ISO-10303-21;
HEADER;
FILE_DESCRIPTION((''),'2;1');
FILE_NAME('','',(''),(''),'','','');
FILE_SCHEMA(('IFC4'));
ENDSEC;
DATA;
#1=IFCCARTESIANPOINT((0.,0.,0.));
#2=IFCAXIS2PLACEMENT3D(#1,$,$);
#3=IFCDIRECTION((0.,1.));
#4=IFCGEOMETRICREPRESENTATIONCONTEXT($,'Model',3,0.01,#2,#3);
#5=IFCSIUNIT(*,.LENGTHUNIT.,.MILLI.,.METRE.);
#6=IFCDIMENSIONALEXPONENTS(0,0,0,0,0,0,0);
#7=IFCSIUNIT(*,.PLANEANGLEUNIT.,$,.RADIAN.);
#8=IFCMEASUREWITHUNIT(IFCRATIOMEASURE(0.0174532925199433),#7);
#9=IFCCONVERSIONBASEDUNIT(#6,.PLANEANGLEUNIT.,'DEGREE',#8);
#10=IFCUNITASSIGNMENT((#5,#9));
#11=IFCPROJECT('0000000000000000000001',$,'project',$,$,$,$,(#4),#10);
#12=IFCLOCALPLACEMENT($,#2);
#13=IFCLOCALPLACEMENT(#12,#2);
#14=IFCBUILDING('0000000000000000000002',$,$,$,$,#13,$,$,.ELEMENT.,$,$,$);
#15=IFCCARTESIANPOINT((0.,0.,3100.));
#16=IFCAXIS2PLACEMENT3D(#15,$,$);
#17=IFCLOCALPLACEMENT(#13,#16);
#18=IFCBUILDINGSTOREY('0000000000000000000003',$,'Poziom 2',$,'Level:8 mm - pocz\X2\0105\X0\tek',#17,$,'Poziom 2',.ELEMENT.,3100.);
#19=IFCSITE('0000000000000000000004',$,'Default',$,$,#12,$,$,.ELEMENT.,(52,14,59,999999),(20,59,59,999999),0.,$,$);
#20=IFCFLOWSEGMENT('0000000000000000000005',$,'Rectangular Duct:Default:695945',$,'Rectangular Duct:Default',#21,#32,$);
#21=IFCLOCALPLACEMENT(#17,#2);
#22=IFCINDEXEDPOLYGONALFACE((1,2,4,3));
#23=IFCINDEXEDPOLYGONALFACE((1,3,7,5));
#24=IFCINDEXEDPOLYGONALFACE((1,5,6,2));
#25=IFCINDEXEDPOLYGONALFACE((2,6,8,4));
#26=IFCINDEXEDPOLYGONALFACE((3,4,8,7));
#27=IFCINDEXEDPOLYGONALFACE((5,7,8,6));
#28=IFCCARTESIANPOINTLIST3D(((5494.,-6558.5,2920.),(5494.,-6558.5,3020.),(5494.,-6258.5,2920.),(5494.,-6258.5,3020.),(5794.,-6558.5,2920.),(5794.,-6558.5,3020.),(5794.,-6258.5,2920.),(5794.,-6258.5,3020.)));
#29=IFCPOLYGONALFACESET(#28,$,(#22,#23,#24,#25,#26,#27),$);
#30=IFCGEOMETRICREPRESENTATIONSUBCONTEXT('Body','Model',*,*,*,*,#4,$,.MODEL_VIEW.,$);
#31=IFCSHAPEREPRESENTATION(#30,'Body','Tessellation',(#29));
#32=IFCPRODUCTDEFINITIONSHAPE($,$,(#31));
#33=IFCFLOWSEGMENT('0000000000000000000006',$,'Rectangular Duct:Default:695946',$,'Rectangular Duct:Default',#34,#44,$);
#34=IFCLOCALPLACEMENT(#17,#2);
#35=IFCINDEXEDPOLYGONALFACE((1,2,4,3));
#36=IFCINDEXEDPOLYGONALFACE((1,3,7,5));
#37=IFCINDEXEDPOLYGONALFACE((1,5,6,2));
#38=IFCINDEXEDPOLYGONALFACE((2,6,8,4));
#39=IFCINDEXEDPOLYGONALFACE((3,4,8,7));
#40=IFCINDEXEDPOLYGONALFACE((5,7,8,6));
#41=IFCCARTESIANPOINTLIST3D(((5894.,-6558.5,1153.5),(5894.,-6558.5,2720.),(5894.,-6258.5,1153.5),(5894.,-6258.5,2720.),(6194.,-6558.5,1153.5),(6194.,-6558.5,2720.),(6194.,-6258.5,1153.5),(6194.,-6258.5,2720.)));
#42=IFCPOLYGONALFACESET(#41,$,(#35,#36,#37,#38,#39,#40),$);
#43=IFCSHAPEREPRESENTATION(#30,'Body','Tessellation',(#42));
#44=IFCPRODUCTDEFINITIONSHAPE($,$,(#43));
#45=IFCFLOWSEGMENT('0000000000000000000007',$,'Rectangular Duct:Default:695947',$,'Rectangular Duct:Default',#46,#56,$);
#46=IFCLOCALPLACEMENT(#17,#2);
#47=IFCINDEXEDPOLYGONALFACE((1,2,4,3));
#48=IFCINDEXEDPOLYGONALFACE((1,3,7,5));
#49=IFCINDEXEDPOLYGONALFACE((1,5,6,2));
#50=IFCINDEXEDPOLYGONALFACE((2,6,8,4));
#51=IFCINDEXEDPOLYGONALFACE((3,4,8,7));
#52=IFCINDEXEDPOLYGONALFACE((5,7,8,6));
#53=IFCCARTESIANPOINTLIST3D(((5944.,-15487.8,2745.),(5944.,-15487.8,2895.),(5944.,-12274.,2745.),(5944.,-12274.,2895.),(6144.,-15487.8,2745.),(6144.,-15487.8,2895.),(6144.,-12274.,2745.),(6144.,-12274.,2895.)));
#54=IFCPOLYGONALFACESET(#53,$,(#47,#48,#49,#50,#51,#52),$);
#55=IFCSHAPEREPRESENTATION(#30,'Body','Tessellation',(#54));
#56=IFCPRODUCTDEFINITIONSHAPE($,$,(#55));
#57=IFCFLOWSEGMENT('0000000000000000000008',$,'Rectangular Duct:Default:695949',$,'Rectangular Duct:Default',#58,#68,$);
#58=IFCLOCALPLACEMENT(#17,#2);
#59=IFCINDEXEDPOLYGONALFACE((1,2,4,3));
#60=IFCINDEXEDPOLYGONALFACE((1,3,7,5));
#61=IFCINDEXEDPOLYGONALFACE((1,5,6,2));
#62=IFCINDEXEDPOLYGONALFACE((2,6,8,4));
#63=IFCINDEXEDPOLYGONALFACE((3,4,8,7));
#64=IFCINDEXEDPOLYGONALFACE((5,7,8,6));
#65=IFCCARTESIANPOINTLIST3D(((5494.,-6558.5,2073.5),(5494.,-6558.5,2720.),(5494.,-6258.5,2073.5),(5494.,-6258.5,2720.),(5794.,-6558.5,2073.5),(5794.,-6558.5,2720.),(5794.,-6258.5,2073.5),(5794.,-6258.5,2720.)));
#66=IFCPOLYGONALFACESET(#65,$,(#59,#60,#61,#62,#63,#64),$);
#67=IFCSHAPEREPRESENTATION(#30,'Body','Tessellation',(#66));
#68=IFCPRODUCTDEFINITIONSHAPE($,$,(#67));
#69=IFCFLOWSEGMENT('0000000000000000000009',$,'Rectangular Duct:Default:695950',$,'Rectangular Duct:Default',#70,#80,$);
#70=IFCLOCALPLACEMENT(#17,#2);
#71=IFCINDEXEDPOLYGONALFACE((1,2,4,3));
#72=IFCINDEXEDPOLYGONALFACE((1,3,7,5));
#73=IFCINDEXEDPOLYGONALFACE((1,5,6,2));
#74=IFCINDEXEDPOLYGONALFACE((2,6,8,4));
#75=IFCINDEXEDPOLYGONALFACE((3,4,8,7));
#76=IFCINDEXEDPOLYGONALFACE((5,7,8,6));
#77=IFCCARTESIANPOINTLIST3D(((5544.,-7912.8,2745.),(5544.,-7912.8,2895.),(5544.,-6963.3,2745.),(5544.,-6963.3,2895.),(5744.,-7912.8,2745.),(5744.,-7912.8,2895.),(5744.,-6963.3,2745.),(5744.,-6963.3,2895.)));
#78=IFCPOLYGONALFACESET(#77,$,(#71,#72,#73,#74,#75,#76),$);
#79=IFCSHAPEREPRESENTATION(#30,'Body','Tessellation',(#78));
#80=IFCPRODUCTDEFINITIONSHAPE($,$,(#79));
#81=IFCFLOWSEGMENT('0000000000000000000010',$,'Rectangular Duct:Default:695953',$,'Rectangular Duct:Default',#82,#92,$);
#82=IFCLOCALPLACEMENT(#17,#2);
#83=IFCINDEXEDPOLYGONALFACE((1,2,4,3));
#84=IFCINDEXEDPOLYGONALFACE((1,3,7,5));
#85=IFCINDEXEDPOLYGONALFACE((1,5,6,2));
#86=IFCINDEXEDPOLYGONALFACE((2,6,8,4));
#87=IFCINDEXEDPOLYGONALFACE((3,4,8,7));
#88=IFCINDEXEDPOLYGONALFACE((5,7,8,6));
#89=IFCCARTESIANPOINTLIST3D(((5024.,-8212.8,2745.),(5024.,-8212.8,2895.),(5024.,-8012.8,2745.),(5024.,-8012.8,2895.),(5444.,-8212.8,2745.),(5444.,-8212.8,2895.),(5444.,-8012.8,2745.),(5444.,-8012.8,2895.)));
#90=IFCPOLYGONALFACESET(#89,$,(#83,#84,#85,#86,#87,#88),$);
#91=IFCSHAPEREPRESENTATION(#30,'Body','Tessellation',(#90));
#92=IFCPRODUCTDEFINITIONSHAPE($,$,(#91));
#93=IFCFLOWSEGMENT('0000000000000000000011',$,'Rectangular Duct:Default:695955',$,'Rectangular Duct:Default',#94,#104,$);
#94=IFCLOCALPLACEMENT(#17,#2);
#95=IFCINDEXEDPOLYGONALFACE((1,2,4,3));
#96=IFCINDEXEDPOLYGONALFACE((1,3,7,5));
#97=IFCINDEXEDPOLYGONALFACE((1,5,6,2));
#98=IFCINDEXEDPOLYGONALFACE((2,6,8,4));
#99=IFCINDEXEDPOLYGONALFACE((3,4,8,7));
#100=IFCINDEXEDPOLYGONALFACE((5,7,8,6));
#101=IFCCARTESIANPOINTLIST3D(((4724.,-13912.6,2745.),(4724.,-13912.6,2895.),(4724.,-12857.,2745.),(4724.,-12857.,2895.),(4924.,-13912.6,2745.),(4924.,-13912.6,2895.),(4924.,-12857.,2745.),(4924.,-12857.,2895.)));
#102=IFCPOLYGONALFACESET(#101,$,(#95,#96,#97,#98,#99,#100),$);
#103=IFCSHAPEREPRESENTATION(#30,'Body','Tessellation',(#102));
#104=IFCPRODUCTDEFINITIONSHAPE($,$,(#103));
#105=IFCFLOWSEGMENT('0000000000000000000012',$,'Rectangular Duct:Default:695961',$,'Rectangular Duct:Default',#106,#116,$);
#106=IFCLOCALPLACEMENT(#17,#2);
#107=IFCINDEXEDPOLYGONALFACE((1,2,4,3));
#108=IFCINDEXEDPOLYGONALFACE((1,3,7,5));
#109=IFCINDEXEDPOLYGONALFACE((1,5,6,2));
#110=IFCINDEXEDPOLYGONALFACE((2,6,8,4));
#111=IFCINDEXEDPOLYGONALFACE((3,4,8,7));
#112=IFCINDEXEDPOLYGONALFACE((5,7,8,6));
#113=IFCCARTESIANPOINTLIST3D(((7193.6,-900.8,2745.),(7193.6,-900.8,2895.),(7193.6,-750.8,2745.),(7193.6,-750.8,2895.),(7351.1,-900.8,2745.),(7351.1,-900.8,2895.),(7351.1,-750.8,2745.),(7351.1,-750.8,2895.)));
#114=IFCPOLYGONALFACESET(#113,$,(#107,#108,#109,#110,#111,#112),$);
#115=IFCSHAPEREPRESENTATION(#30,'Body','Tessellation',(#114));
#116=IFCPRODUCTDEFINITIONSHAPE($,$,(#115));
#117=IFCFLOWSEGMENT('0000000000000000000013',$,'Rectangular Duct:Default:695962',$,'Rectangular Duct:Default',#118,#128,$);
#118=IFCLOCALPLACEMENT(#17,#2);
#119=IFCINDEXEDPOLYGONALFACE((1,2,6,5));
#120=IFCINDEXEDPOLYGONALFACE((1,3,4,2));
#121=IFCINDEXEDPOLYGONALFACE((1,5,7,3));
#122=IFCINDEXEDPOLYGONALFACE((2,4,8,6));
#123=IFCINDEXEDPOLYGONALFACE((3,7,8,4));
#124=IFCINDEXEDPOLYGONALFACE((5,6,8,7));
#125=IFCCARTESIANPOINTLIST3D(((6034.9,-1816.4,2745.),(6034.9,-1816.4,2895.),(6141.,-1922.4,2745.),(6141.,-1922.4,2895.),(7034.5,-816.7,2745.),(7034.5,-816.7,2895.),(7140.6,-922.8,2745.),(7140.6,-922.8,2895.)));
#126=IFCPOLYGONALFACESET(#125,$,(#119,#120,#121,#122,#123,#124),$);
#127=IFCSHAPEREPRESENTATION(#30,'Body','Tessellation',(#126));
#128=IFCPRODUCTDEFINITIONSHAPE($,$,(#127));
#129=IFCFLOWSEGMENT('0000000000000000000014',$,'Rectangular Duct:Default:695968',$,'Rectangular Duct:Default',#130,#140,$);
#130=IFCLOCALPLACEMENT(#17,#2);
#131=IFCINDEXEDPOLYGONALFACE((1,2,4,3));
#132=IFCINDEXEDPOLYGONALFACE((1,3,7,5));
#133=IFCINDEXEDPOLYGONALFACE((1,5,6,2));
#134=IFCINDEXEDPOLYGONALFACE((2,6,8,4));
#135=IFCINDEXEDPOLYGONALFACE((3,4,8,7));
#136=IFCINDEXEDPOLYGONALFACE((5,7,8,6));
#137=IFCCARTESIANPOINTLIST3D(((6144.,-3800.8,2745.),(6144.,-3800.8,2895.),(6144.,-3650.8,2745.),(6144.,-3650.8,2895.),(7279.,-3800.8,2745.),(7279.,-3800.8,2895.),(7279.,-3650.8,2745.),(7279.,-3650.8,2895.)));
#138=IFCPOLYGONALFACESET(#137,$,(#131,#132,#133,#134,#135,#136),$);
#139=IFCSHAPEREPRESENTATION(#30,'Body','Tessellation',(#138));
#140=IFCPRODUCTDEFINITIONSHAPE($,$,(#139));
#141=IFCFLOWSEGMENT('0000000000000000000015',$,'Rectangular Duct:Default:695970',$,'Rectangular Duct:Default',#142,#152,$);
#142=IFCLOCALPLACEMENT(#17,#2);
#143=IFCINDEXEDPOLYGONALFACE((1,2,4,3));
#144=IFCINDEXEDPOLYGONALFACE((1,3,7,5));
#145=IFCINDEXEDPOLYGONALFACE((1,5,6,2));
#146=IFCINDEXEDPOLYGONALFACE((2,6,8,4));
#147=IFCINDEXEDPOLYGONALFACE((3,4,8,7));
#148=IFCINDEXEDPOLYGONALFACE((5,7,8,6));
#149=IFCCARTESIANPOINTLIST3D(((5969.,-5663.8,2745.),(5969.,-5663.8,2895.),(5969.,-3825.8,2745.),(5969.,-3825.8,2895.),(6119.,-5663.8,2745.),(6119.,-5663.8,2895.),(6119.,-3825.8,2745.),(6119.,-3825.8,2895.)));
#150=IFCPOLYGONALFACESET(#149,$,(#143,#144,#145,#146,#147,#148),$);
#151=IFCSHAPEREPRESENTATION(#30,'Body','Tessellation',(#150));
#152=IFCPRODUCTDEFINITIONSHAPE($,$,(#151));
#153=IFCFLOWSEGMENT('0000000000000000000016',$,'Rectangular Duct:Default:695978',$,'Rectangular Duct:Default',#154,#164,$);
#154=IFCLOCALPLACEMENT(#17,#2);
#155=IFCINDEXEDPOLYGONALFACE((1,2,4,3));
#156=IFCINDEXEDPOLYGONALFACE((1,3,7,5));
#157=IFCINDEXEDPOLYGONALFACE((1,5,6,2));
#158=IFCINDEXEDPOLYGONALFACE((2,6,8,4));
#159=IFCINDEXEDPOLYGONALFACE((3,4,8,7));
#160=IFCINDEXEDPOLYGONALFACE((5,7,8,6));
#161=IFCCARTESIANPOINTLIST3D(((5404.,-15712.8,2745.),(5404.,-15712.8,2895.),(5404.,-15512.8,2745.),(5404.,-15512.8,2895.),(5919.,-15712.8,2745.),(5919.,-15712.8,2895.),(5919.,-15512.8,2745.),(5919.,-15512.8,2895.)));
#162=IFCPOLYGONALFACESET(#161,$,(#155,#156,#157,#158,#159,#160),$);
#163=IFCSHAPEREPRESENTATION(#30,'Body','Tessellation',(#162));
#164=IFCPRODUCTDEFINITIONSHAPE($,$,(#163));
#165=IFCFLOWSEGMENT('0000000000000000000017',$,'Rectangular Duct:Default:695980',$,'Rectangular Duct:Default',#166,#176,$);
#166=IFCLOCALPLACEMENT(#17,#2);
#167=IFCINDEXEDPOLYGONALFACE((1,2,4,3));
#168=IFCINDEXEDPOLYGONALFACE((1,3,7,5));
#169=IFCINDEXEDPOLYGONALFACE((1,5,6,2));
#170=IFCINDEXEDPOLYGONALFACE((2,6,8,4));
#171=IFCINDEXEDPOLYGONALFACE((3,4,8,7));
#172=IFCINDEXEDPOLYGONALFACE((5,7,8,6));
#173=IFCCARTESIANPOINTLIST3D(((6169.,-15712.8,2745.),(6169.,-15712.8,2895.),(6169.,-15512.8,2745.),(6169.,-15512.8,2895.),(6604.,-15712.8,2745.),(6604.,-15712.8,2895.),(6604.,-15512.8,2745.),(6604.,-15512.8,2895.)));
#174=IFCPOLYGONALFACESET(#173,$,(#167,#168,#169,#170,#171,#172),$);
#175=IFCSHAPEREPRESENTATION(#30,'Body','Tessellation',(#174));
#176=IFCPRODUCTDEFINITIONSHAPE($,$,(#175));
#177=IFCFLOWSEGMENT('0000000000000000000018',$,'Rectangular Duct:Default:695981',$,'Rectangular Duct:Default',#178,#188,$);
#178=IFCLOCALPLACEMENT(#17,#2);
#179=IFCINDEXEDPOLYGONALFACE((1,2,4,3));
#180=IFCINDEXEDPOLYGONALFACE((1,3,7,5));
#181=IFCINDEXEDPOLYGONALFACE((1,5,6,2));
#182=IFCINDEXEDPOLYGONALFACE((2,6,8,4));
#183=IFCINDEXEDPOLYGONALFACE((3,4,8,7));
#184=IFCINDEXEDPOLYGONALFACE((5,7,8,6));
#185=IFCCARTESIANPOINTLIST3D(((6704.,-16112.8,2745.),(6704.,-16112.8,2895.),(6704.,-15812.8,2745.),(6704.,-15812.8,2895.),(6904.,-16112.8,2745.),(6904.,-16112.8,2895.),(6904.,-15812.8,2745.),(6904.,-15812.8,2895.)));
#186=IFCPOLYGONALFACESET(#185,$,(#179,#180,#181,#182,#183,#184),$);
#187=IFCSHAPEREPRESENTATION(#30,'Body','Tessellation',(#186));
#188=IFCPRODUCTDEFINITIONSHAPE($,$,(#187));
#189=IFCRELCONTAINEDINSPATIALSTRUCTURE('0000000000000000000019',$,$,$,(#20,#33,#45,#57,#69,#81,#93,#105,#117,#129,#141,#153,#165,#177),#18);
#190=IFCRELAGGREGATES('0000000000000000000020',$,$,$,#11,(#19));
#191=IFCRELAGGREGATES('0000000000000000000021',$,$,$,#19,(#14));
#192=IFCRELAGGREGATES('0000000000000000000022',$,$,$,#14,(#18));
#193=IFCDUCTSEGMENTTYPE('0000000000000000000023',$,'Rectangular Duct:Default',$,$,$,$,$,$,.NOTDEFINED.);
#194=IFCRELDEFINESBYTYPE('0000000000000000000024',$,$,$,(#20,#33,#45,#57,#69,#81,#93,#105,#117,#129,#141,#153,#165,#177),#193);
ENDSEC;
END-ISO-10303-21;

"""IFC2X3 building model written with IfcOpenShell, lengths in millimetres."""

from ifc_helpers import new_model, entity, si_unit, converted_unit, direction, frame, frame_2d, origin, origin_2d_with_axis, place, context, subcontext, project, spatial, rectangle, extrude, type_object, element, save


model = new_model("IFC2X3")

# Units and contexts
model_context = context("Model", 3, precision=0.01, world=origin(), true_north=direction((0.0, 1.0)))
body_context = subcontext(model_context, "Body", "Model", "MODEL_VIEW")
ifc_project = project(units=[si_unit("LENGTHUNIT", "METRE", prefix="MILLI"), converted_unit("PLANEANGLEUNIT", "DEGREE", entity("IfcRatioMeasure", 0.0174532925199433), si_unit("PLANEANGLEUNIT", "RADIAN"), dimensions=[0, 0, 0, 0, 0, 0, 0])], contexts=[model_context])

# Site, building, storey
site_placement = place(None, origin())
site = spatial("IfcSite", under=ifc_project, at=site_placement, Name="Default", CompositionType="ELEMENT", RefLatitude=(52, 14, 59, 999999), RefLongitude=(20, 59, 59, 999999), RefElevation=0.0)
building_placement = place(site_placement, origin())
building = spatial("IfcBuilding", under=site, at=building_placement, CompositionType="ELEMENT")
storey_placement = place(building_placement, frame((0.0, 0.0, 3100.0)))
storey = spatial("IfcBuildingStorey", under=building, at=storey_placement, Name="Poziom 2", ObjectType="Level:8 mm - początek", LongName="Poziom 2", CompositionType="ELEMENT", Elevation=3100.0)

# Flow segments
duct_segment_type = type_object("IfcDuctSegmentType", Name="Rectangular Duct:Default", PredefinedType="NOTDEFINED")
flow_segment_1_placement = place(storey_placement, origin())
element("IfcFlowSegment", 1, at=flow_segment_1_placement, inside=storey, type_object=duct_segment_type, Name="Rectangular Duct:Default:695945", ObjectType="Rectangular Duct:Default", context=body_context, shape_type="SweptSolid", body=[
    extrude(rectangle(XDim=300.0, YDim=300.0, at=frame_2d((0.0, 0.0), x_axis=(1.0, 0.0))), frame((5644.0, -6408.5, 2920.0), z_axis=(0.0, 0.0, 1.0), x_axis=(0.0, 1.0, 0.0)), (0.0, 0.0, 1.0), 100.0),
])
flow_segment_2_placement = place(storey_placement, origin())
element("IfcFlowSegment", 2, at=flow_segment_2_placement, inside=storey, type_object=duct_segment_type, Name="Rectangular Duct:Default:695946", ObjectType="Rectangular Duct:Default", context=body_context, shape_type="SweptSolid", body=[
    extrude(rectangle(XDim=300.0, YDim=300.0, at=frame_2d((0.0, 0.0), x_axis=(1.0, 0.0))), frame((6044.0, -6408.5, 1153.5), z_axis=(0.0, 0.0, 1.0), x_axis=(0.0, -1.0, 0.0)), (0.0, 0.0, 1.0), 1566.5),
])
flow_segment_3_placement = place(storey_placement, origin())
element("IfcFlowSegment", 3, at=flow_segment_3_placement, inside=storey, type_object=duct_segment_type, Name="Rectangular Duct:Default:695947", ObjectType="Rectangular Duct:Default", context=body_context, shape_type="SweptSolid", body=[
    extrude(rectangle(XDim=3213.8, YDim=200.0, at=origin_2d_with_axis()), frame((6044.0, -13880.9, 2745.0), z_axis=(0.0, 0.0, 1.0), x_axis=(0.0, -1.0, 0.0)), (0.0, 0.0, 1.0), 150.0),
])
flow_segment_4_placement = place(storey_placement, origin())
element("IfcFlowSegment", 4, at=flow_segment_4_placement, inside=storey, type_object=duct_segment_type, Name="Rectangular Duct:Default:695949", ObjectType="Rectangular Duct:Default", context=body_context, shape_type="SweptSolid", body=[
    extrude(rectangle(XDim=300.0, YDim=300.0, at=frame_2d((0.0, 0.0), x_axis=(1.0, 0.0))), frame((5644.0, -6408.5, 2073.5), z_axis=(0.0, 0.0, 1.0), x_axis=(0.0, 1.0, 0.0)), (0.0, 0.0, 1.0), 646.5),
])
flow_segment_5_placement = place(storey_placement, origin())
element("IfcFlowSegment", 5, at=flow_segment_5_placement, inside=storey, type_object=duct_segment_type, Name="Rectangular Duct:Default:695950", ObjectType="Rectangular Duct:Default", context=body_context, shape_type="SweptSolid", body=[
    extrude(rectangle(XDim=949.5, YDim=200.0, at=frame_2d((0.0, 0.0), x_axis=(1.0, 0.0))), frame((5644.0, -7438.0, 2745.0), z_axis=(0.0, 0.0, 1.0), x_axis=(0.0, -1.0, 0.0)), (0.0, 0.0, 1.0), 150.0),
])
flow_segment_6_placement = place(storey_placement, origin())
element("IfcFlowSegment", 6, at=flow_segment_6_placement, inside=storey, type_object=duct_segment_type, Name="Rectangular Duct:Default:695953", ObjectType="Rectangular Duct:Default", context=body_context, shape_type="SweptSolid", body=[
    extrude(rectangle(XDim=420.0, YDim=200.0, at=origin_2d_with_axis()), frame((5234.0, -8112.8, 2745.0), z_axis=(0.0, 0.0, 1.0), x_axis=(-1.0, 0.0, 0.0)), (0.0, 0.0, 1.0), 150.0),
])
flow_segment_7_placement = place(storey_placement, origin())
element("IfcFlowSegment", 7, at=flow_segment_7_placement, inside=storey, type_object=duct_segment_type, Name="Rectangular Duct:Default:695955", ObjectType="Rectangular Duct:Default", context=body_context, shape_type="SweptSolid", body=[
    extrude(rectangle(XDim=1055.6, YDim=200.0, at=frame_2d((0.0, 0.0), x_axis=(1.0, 0.0))), frame((4824.0, -13384.8, 2745.0), z_axis=(0.0, 0.0, 1.0), x_axis=(0.0, -1.0, 0.0)), (0.0, 0.0, 1.0), 150.0),
])
flow_segment_8_placement = place(storey_placement, origin())
element("IfcFlowSegment", 8, at=flow_segment_8_placement, inside=storey, type_object=duct_segment_type, Name="Rectangular Duct:Default:695961", ObjectType="Rectangular Duct:Default", context=body_context, shape_type="SweptSolid", body=[
    extrude(rectangle(XDim=157.5, YDim=150.0, at=frame_2d((0.0, 0.0), x_axis=(1.0, 0.0))), frame((7272.4, -825.8, 2745.0)), (0.0, 0.0, 1.0), 150.0),
])
flow_segment_9_placement = place(storey_placement, origin())
element("IfcFlowSegment", 9, at=flow_segment_9_placement, inside=storey, type_object=duct_segment_type, Name="Rectangular Duct:Default:695962", ObjectType="Rectangular Duct:Default", context=body_context, shape_type="SweptSolid", body=[
    extrude(rectangle(XDim=1413.7, YDim=150.0, at=frame_2d((0.0, 0.0), x_axis=(1.0, 0.0))), frame((6587.7, -1369.6, 2745.0), z_axis=(0.0, 0.0, 1.0), x_axis=(0.707107, 0.707107, 0.0)), (0.0, 0.0, 1.0), 150.0),
])
flow_segment_10_placement = place(storey_placement, origin())
element("IfcFlowSegment", 10, at=flow_segment_10_placement, inside=storey, type_object=duct_segment_type, Name="Rectangular Duct:Default:695968", ObjectType="Rectangular Duct:Default", context=body_context, shape_type="SweptSolid", body=[
    extrude(rectangle(XDim=1135.0, YDim=150.0, at=frame_2d((0.0, 0.0), x_axis=(1.0, 0.0))), frame((6711.5, -3725.8, 2745.0)), (0.0, 0.0, 1.0), 150.0),
])
flow_segment_11_placement = place(storey_placement, origin())
element("IfcFlowSegment", 11, at=flow_segment_11_placement, inside=storey, type_object=duct_segment_type, Name="Rectangular Duct:Default:695970", ObjectType="Rectangular Duct:Default", context=body_context, shape_type="SweptSolid", body=[
    extrude(rectangle(XDim=1838.0, YDim=150.0, at=frame_2d((0.0, 0.0), x_axis=(1.0, 0.0))), frame((6044.0, -4744.8, 2745.0), z_axis=(0.0, 0.0, 1.0), x_axis=(0.0, 1.0, 0.0)), (0.0, 0.0, 1.0), 150.0),
])
flow_segment_12_placement = place(storey_placement, origin())
element("IfcFlowSegment", 12, at=flow_segment_12_placement, inside=storey, type_object=duct_segment_type, Name="Rectangular Duct:Default:695978", ObjectType="Rectangular Duct:Default", context=body_context, shape_type="SweptSolid", body=[
    extrude(rectangle(XDim=515.0, YDim=200.0, at=frame_2d((0.0, 0.0), x_axis=(1.0, 0.0))), frame((5661.5, -15612.8, 2745.0), z_axis=(0.0, 0.0, 1.0), x_axis=(-1.0, 0.0, 0.0)), (0.0, 0.0, 1.0), 150.0),
])
flow_segment_13_placement = place(storey_placement, origin())
element("IfcFlowSegment", 13, at=flow_segment_13_placement, inside=storey, type_object=duct_segment_type, Name="Rectangular Duct:Default:695980", ObjectType="Rectangular Duct:Default", context=body_context, shape_type="SweptSolid", body=[
    extrude(rectangle(XDim=435.0, YDim=200.0, at=frame_2d((0.0, 0.0), x_axis=(1.0, 0.0))), frame((6386.5, -15612.8, 2745.0), z_axis=(0.0, 0.0, 1.0), x_axis=(-1.0, 0.0, 0.0)), (0.0, 0.0, 1.0), 150.0),
])
flow_segment_14_placement = place(storey_placement, origin())
element("IfcFlowSegment", 14, at=flow_segment_14_placement, inside=storey, type_object=duct_segment_type, Name="Rectangular Duct:Default:695981", ObjectType="Rectangular Duct:Default", context=body_context, shape_type="SweptSolid", body=[
    extrude(rectangle(XDim=300.0, YDim=200.0, at=frame_2d((0.0, 0.0), x_axis=(1.0, 0.0))), frame((6804.0, -15962.8, 2745.0), z_axis=(0.0, 0.0, 1.0), x_axis=(0.0, -1.0, 0.0)), (0.0, 0.0, 1.0), 150.0),
])

save(model, "model.ifc")
